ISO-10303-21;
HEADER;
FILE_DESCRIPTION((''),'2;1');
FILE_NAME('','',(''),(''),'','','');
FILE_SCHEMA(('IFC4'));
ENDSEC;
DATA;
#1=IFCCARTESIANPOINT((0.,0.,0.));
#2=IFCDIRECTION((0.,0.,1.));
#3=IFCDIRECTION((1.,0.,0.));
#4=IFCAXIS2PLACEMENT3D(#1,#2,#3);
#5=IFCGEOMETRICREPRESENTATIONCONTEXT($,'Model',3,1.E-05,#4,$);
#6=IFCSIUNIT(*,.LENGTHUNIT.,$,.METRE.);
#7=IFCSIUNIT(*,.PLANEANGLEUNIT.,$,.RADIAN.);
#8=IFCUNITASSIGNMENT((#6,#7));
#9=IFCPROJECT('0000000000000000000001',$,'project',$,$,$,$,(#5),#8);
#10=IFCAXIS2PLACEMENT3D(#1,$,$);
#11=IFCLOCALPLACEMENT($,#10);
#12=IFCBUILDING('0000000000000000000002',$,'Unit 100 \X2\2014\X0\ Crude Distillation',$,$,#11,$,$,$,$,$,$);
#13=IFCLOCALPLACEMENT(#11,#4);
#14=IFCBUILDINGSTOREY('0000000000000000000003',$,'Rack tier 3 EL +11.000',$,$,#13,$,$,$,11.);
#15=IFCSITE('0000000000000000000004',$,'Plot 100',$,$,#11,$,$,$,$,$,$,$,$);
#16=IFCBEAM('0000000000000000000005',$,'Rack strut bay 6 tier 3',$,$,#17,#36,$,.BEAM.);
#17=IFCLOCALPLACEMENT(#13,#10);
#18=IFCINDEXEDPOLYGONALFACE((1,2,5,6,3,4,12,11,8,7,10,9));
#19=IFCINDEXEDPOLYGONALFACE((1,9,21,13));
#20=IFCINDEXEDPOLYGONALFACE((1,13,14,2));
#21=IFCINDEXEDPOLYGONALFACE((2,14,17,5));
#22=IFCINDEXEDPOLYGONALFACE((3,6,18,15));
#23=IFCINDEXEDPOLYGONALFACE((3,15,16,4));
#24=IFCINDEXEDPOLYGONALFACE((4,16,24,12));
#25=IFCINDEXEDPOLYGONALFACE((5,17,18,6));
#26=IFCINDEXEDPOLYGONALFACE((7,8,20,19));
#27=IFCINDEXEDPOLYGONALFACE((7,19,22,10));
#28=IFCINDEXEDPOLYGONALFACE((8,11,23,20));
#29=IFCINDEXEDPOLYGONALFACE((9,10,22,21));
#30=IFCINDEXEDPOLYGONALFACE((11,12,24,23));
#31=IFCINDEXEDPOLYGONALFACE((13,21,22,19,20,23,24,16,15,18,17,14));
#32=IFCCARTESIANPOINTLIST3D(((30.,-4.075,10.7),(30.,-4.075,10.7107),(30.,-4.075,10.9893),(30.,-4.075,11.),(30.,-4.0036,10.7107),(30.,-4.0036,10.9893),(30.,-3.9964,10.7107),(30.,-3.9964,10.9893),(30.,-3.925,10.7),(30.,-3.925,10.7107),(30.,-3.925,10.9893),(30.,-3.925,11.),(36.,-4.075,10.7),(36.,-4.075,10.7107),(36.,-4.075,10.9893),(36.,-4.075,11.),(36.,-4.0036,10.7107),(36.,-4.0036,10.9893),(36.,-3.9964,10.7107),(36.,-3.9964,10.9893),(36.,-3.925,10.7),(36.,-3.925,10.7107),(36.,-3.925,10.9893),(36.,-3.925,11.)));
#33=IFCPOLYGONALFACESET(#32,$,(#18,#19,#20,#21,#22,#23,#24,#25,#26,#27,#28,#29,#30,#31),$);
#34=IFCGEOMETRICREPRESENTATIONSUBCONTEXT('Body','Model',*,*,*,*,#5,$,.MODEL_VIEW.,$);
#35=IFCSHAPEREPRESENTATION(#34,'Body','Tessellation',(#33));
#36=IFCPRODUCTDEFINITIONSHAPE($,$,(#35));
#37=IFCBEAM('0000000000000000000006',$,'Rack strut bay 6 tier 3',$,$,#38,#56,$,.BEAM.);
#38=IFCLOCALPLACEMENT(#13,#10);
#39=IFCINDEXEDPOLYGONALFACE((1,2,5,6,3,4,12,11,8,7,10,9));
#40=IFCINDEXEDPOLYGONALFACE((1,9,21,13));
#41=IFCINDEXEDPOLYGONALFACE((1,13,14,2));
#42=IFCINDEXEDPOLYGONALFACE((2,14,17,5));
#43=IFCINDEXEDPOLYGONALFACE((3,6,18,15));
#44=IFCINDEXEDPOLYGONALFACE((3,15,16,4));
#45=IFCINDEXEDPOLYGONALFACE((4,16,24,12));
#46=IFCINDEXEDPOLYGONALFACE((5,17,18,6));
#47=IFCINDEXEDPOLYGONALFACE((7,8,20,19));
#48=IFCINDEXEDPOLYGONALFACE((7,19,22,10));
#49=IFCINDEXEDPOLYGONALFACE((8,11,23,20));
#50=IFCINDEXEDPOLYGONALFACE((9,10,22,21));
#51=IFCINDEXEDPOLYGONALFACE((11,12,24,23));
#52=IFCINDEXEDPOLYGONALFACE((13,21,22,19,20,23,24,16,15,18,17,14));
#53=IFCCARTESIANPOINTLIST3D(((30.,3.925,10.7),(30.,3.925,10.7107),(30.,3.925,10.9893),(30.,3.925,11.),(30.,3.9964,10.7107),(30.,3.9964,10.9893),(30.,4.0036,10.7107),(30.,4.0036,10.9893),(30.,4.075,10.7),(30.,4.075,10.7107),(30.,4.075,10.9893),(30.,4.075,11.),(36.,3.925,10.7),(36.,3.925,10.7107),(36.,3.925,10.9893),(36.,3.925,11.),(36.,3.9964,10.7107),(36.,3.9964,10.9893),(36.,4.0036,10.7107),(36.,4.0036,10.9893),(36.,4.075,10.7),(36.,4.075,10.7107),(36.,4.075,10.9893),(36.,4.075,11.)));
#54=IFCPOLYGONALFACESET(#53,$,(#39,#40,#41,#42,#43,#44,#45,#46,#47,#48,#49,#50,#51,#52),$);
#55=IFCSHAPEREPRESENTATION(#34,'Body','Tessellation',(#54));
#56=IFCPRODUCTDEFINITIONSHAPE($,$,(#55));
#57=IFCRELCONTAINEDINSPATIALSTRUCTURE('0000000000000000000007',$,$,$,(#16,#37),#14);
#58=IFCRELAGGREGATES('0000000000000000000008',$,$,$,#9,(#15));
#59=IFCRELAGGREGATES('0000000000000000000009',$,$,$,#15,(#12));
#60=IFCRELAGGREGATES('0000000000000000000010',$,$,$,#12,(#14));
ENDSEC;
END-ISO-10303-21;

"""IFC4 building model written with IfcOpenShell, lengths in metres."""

from ifc_helpers import new_model, si_unit, frame, origin, origin_with_axes, origin_2d, place, context, subcontext, project, spatial, i_section, extrude, element, save


model = new_model("IFC4")

# Units and contexts
model_context = context("Model", 3, precision=1e-05, world=origin_with_axes())
body_context = subcontext(model_context, "Body", "Model", "MODEL_VIEW")
ifc_project = project(units=[si_unit("LENGTHUNIT", "METRE"), si_unit("PLANEANGLEUNIT", "RADIAN")], contexts=[model_context])

# Site, building, storey
placement = place(None, origin())
site = spatial("IfcSite", under=ifc_project, at=placement, Name="Plot 100")
building = spatial("IfcBuilding", under=site, at=placement, Name="Unit 100 — Crude Distillation")
storey_placement = place(placement, origin_with_axes())
storey = spatial("IfcBuildingStorey", under=building, at=storey_placement, Name="Rack tier 3 EL +11.000", Elevation=11.0)

# Beams
beam_1_placement = place(storey_placement, origin_with_axes())
element("IfcBeam", 1, at=beam_1_placement, inside=storey, Name="Rack strut bay 6 tier 3", PredefinedType="BEAM", context=body_context, shape_type="SweptSolid", body=[
    extrude(i_section(OverallWidth=0.15, OverallDepth=0.3, WebThickness=0.0071, FlangeThickness=0.0107, at=origin_2d()), frame((30.0, -4.0, 10.85), z_axis=(1.0, 0.0, 0.0), x_axis=(0.0, 1.0, 0.0)), (0.0, 0.0, 1.0), 6.0),
])
beam_2_placement = place(storey_placement, origin_with_axes())
element("IfcBeam", 2, at=beam_2_placement, inside=storey, Name="Rack strut bay 6 tier 3", PredefinedType="BEAM", context=body_context, shape_type="SweptSolid", body=[
    extrude(i_section(OverallWidth=0.15, OverallDepth=0.3, WebThickness=0.0071, FlangeThickness=0.0107, at=origin_2d()), frame((30.0, 4.0, 10.85), z_axis=(1.0, 0.0, 0.0), x_axis=(0.0, 1.0, 0.0)), (0.0, 0.0, 1.0), 6.0),
])

save(model, "model.ifc")
